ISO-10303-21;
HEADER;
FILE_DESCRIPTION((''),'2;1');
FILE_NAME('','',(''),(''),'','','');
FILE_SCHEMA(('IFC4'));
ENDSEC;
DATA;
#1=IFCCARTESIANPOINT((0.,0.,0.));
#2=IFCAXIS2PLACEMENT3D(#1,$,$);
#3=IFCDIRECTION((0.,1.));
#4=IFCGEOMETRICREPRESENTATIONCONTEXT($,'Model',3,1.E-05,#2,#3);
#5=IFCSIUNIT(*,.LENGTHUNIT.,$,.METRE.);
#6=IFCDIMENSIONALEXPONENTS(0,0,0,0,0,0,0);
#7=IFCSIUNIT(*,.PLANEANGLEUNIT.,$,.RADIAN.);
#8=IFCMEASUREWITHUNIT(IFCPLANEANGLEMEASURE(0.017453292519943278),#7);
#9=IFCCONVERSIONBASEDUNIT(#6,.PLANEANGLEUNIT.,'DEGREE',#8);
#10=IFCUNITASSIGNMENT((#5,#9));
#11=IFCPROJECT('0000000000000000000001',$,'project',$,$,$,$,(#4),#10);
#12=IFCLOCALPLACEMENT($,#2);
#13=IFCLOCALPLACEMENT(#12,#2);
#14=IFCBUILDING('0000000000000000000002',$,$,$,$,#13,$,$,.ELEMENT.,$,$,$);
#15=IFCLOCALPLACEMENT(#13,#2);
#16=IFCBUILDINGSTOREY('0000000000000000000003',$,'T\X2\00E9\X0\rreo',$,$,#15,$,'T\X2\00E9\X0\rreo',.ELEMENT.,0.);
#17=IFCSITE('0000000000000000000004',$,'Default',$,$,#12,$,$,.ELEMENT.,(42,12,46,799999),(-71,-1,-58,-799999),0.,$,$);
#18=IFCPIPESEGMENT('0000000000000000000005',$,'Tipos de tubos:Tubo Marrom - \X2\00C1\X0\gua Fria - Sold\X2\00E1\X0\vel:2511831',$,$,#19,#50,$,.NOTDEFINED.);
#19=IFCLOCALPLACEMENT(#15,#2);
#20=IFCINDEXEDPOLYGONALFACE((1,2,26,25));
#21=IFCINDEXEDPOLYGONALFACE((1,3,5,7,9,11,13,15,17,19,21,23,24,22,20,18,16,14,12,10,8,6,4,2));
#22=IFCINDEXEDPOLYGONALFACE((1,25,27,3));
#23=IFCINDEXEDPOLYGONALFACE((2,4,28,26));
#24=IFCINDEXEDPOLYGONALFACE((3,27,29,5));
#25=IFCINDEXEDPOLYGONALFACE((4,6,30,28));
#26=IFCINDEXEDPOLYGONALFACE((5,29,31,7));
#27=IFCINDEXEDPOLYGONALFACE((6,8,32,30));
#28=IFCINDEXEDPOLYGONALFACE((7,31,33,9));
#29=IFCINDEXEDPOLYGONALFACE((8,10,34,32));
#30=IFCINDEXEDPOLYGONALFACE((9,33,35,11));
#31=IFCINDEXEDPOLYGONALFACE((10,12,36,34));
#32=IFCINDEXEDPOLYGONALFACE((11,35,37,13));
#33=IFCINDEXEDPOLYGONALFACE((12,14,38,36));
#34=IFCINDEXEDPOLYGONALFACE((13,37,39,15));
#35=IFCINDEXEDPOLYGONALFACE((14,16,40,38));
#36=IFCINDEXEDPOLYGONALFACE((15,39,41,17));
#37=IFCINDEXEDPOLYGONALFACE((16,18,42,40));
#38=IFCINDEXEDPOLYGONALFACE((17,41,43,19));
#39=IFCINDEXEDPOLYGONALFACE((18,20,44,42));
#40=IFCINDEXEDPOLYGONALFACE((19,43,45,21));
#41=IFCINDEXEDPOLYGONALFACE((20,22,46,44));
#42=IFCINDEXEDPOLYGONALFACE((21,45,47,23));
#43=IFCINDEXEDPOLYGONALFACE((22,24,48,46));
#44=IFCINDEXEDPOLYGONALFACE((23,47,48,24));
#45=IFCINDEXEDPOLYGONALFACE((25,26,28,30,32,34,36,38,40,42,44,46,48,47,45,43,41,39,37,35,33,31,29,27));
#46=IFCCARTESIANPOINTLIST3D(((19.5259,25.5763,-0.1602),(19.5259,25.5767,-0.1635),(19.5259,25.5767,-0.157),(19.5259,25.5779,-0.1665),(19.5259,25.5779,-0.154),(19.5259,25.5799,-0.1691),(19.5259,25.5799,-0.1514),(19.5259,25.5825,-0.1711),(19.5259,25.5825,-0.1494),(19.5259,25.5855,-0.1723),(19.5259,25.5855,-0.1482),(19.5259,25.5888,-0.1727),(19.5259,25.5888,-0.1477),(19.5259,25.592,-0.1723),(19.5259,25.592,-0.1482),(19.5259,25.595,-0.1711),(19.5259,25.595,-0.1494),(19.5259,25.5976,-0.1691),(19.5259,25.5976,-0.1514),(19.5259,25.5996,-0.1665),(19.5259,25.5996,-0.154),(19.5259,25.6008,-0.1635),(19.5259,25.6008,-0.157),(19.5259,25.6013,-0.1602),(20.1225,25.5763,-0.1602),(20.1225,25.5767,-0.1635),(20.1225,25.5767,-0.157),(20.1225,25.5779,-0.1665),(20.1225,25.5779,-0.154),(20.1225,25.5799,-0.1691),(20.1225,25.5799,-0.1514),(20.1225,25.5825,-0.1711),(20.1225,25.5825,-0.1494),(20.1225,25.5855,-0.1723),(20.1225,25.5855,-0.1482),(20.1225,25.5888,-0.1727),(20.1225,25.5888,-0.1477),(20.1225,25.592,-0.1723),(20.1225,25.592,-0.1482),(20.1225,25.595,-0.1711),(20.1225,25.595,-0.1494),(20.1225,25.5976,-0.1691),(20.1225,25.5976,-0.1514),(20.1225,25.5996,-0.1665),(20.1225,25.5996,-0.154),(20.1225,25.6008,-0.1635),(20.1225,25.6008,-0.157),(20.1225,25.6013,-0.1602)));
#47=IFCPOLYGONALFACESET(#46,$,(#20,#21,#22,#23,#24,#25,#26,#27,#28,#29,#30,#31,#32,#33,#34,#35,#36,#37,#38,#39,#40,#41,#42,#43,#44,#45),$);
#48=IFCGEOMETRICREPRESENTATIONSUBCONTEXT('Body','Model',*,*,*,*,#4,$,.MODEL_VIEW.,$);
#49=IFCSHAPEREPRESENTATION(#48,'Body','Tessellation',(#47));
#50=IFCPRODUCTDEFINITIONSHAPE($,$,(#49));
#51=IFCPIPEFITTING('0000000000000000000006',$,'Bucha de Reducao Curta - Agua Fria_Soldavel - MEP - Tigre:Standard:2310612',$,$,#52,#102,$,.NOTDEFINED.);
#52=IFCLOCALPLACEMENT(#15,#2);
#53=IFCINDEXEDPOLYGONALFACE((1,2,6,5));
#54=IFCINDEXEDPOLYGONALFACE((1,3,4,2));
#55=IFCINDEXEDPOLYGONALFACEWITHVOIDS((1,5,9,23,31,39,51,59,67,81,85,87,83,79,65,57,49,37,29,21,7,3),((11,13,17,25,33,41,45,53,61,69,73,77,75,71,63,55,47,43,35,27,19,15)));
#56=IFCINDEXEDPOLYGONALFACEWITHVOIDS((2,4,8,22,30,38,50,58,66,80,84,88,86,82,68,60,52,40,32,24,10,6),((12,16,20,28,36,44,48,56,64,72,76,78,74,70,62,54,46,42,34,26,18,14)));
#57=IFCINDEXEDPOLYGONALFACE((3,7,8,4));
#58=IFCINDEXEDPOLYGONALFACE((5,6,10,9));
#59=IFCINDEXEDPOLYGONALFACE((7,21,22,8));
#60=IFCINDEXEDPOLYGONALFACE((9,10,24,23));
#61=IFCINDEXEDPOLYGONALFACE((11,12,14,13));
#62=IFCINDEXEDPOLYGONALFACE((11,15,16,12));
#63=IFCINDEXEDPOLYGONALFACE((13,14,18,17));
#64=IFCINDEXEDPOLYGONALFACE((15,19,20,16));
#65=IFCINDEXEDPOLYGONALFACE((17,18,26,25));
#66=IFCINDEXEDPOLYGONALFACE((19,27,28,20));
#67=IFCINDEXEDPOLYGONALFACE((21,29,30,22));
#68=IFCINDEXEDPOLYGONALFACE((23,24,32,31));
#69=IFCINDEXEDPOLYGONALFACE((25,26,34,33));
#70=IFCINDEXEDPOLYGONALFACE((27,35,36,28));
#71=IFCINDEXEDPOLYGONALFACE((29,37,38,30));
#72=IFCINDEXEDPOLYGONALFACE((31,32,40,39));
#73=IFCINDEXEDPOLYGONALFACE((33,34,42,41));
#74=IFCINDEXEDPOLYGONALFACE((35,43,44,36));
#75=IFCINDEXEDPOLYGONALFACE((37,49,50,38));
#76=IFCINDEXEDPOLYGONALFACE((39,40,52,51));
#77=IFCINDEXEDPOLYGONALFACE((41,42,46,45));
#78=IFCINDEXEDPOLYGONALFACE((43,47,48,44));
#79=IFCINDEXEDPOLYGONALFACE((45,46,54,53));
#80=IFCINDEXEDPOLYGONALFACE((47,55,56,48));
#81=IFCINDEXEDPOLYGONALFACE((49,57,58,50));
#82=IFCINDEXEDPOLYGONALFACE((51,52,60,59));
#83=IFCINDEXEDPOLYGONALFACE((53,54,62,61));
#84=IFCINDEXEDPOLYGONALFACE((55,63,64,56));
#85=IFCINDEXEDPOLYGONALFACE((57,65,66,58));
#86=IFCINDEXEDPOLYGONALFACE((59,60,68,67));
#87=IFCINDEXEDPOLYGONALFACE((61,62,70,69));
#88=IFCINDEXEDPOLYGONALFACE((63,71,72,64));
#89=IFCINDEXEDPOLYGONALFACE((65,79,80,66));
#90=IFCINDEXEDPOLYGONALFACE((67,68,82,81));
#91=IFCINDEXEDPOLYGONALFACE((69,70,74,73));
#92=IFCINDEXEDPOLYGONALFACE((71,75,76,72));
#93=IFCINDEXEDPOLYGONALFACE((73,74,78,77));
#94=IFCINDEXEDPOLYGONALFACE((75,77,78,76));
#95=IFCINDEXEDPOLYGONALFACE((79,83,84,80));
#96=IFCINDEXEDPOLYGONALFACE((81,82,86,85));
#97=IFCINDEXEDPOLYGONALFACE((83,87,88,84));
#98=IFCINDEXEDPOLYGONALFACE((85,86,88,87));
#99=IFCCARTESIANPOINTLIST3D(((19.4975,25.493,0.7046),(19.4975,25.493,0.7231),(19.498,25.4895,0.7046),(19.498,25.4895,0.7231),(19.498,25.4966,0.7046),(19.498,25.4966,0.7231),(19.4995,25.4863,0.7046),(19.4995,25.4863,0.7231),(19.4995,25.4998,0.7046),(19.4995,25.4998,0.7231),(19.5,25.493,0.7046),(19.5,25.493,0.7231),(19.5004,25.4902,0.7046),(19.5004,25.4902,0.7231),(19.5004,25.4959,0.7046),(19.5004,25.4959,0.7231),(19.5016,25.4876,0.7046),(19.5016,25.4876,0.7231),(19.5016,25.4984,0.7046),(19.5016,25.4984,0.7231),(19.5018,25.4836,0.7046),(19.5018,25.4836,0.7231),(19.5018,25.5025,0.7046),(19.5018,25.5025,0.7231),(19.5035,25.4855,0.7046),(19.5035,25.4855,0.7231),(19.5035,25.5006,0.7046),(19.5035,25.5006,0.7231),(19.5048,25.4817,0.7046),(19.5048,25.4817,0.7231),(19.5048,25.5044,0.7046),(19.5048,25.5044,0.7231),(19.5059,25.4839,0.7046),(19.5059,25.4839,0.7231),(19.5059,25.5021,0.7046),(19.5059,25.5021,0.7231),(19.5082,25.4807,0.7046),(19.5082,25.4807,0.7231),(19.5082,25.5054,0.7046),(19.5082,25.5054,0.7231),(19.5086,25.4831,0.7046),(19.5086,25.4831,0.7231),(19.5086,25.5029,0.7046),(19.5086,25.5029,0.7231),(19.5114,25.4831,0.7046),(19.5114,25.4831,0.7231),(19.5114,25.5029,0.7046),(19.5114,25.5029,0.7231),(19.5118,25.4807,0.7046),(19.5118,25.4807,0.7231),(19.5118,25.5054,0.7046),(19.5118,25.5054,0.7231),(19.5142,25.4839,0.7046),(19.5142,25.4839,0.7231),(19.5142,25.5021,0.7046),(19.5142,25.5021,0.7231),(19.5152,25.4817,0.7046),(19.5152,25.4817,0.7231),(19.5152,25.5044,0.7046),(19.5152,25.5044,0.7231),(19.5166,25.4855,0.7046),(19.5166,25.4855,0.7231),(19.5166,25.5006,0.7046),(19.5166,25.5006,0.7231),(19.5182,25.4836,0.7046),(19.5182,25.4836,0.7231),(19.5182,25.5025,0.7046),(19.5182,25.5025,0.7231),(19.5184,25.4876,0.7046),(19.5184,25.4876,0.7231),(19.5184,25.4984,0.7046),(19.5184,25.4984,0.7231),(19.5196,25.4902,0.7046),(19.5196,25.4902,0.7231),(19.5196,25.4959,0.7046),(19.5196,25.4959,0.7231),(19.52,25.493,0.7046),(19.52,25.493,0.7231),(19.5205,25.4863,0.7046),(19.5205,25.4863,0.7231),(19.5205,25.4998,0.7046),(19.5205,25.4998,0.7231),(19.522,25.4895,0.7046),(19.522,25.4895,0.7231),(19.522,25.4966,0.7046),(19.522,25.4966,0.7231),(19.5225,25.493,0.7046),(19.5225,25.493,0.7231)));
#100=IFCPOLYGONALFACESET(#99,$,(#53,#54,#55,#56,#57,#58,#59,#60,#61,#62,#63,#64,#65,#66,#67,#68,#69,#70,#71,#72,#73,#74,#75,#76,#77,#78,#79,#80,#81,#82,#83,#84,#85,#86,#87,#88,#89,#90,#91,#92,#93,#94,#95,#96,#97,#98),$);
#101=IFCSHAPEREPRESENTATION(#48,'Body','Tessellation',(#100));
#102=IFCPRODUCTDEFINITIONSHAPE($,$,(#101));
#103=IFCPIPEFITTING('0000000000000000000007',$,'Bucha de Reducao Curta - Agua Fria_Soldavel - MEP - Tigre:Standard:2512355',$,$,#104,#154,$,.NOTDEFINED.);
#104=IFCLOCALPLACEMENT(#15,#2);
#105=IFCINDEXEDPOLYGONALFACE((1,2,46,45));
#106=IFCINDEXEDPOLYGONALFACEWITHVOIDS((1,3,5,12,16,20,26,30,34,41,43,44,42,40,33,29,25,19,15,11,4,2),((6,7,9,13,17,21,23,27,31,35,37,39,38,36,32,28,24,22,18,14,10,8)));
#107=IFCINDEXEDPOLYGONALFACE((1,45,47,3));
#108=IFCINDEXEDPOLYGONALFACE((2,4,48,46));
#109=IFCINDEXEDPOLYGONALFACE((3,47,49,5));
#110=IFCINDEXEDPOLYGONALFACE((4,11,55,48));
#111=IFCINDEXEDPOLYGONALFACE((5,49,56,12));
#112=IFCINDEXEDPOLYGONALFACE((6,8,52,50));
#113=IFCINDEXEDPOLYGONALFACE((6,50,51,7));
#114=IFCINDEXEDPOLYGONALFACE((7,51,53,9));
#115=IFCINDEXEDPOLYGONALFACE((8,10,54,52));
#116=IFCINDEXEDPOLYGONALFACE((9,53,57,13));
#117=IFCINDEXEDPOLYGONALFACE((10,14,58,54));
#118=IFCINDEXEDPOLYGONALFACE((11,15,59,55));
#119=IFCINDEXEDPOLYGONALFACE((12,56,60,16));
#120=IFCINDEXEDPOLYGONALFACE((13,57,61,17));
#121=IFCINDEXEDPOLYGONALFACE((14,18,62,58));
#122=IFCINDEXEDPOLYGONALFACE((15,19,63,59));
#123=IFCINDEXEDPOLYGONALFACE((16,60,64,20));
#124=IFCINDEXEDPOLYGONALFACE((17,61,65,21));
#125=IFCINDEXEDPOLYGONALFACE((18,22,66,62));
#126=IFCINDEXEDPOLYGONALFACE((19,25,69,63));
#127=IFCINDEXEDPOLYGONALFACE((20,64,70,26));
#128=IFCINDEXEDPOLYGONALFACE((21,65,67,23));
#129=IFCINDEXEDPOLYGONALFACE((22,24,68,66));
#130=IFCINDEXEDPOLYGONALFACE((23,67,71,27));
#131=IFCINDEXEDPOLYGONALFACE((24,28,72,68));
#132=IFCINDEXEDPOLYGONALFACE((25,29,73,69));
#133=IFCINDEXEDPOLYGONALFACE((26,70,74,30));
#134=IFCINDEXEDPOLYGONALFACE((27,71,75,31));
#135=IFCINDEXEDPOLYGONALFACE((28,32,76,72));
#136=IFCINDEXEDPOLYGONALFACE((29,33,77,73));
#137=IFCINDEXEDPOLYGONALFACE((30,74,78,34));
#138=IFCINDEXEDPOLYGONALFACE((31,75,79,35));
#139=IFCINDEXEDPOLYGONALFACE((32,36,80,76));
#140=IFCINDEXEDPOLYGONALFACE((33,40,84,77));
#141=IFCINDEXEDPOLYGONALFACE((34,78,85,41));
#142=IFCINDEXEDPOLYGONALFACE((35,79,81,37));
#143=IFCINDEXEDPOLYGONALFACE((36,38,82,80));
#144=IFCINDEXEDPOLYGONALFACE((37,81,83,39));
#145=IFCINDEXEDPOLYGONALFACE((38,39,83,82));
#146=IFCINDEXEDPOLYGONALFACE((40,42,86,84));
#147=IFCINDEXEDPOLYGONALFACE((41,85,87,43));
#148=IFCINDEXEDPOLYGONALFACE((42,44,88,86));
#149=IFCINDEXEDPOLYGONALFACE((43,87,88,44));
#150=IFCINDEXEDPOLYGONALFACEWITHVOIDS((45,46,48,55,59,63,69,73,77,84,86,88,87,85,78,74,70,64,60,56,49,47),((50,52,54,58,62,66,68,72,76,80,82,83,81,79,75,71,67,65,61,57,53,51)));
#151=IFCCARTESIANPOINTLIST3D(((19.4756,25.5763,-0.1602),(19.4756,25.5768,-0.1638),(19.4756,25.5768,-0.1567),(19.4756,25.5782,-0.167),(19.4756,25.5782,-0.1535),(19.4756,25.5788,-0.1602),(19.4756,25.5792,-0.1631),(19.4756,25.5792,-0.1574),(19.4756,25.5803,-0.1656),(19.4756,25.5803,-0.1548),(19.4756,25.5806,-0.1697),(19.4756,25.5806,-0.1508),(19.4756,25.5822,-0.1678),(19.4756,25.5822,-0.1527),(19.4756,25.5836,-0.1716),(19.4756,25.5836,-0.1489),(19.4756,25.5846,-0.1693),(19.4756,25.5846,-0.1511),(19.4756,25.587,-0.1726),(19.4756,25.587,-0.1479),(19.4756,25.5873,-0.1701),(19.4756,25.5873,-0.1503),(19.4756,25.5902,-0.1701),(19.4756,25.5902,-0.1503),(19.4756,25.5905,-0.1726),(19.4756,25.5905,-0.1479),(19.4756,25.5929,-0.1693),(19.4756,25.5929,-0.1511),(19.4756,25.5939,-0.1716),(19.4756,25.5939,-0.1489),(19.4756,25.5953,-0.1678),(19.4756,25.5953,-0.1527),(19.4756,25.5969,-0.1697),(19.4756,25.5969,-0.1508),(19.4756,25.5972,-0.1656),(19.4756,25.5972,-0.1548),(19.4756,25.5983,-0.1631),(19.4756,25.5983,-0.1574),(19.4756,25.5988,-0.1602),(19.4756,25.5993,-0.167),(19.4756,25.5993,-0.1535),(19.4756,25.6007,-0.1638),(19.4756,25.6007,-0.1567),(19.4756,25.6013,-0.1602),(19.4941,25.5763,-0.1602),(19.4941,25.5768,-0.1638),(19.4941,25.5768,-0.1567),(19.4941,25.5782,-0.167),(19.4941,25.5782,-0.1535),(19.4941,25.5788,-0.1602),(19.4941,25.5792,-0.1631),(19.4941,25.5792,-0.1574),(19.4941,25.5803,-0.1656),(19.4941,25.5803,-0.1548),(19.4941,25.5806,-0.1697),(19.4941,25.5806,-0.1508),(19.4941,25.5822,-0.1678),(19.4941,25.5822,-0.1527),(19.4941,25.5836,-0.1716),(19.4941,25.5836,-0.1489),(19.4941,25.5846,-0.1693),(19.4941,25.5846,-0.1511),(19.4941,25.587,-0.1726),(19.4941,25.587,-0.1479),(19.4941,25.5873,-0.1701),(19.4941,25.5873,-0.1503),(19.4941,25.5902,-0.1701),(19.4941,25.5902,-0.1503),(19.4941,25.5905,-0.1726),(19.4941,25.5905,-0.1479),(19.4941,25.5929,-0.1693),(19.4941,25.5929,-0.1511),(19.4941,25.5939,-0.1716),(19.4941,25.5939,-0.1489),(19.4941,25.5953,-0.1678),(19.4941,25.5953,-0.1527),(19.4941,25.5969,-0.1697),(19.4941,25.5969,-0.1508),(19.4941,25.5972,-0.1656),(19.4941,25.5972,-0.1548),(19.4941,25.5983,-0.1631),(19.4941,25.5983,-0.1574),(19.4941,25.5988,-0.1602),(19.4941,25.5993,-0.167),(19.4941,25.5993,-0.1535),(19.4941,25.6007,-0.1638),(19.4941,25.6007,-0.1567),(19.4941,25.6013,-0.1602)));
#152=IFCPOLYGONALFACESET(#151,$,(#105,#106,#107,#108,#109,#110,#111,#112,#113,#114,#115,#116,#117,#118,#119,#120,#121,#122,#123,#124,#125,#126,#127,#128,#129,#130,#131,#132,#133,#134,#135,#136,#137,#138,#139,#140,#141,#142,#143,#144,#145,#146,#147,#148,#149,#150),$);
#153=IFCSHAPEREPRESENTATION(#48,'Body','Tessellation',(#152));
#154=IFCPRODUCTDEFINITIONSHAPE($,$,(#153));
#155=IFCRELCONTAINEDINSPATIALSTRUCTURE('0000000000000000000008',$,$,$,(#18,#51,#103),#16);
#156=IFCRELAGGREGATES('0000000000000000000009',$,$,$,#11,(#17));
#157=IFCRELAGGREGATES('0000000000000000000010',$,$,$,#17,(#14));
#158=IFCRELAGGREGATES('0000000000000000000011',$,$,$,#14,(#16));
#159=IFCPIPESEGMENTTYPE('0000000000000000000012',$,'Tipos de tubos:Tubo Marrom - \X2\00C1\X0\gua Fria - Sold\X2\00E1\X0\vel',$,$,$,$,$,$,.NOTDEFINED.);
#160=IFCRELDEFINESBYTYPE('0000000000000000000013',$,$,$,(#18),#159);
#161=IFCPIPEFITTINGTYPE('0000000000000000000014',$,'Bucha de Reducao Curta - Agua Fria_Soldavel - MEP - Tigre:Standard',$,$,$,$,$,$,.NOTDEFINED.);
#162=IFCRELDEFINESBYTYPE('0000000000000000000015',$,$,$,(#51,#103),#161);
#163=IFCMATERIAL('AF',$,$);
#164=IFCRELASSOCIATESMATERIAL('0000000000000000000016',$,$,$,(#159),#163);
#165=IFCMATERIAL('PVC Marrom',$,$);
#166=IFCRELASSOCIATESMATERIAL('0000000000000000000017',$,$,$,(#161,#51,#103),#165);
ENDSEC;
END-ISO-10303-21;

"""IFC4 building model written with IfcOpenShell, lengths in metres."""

from ifc_helpers import new_model, entity, si_unit, converted_unit, direction, frame, origin, place, context, subcontext, project, spatial, arc, indexed_curve, outline, extrude, source, transform, mapped, material, type_object, type_shapes, element, save


model = new_model("IFC4")

# Units and contexts
model_context = context("Model", 3, precision=1e-05, world=origin(), true_north=direction((0.0, 1.0)))
body_context = subcontext(model_context, "Body", "Model", "MODEL_VIEW")
ifc_project = project(units=[si_unit("LENGTHUNIT", "METRE"), converted_unit("PLANEANGLEUNIT", "DEGREE", entity("IfcPlaneAngleMeasure", 0.017453292519943278), si_unit("PLANEANGLEUNIT", "RADIAN"), dimensions=[0, 0, 0, 0, 0, 0, 0])], contexts=[model_context])

# Site, building, storey
site_placement = place(None, origin())
site = spatial("IfcSite", under=ifc_project, at=site_placement, Name="Default", CompositionType="ELEMENT", RefLatitude=(42, 12, 46, 799999), RefLongitude=(-71, -1, -58, -799999), RefElevation=0.0)
building_placement = place(site_placement, origin())
building = spatial("IfcBuilding", under=site, at=building_placement, CompositionType="ELEMENT")
storey_placement = place(building_placement, origin())
storey = spatial("IfcBuildingStorey", under=building, at=storey_placement, Name="Térreo", LongName="Térreo", CompositionType="ELEMENT", Elevation=0.0)

# Pipe segment
ifc_material_1 = material(Name="AF")
pipe_segment_type_1 = type_object("IfcPipeSegmentType", Name="Tipos de tubos:Tubo Marrom - Água Fria - Soldável", PredefinedType="NOTDEFINED", material=ifc_material_1)
pipe_segment_1_placement = place(storey_placement, origin())
element("IfcPipeSegment", 1, at=pipe_segment_1_placement, inside=storey, type_object=pipe_segment_type_1, Name="Tipos de tubos:Tubo Marrom - Água Fria - Soldável:2511831", PredefinedType="NOTDEFINED", context=body_context, shape_type="SweptSolid", body=[
    extrude(outline(indexed_curve([(0.0125, 0.0), (0.0088, 0.0088), (0.0, 0.0125), (-0.0088, 0.0088), (-0.0125, 0.0), (-0.0088, -0.0088), (0.0, -0.0125), (0.0088, -0.0088)], segments=[arc(1, 2, 3), arc(3, 4, 5), arc(5, 6, 7), arc(7, 8, 1)], self_intersect=False)), frame((19.5259, 25.5888, -0.1602), z_axis=(1.0, 0.0, 0.0), x_axis=(0.0, -1.0, 0.0)), (0.0, 0.0, 1.0), 0.5966),
])

# Pipe fittings
ifc_material_2 = material(Name="PVC Marrom")
pipe_fitting_type_1 = type_object("IfcPipeFittingType", Name="Bucha de Reducao Curta - Agua Fria_Soldavel - MEP - Tigre:Standard", PredefinedType="NOTDEFINED", material=ifc_material_2)
shared_shape_1 = source(origin(), body_context, "Body", "SweptSolid", [
    extrude(outline(indexed_curve([(-0.0125, 0.0), (0.0, -0.0125), (0.0125, 0.0), (0.0, 0.0125)], segments=[arc(1, 2, 3), arc(3, 4, 1)], self_intersect=False), holes=[indexed_curve([(-0.01, 0.0), (0.0, 0.01), (0.01, 0.0), (0.0, -0.01)], segments=[arc(1, 2, 3), arc(3, 4, 1)], self_intersect=False)]), frame((0.0, 0.0, 0.0), z_axis=(1.0, 0.0, 0.0), x_axis=(0.0, 1.0, 0.0)), (0.0, 0.0, 1.0), 0.0185),
])
type_shapes(pipe_fitting_type_1, [shared_shape_1])
for number, where, z_axis, x_axis, name in (
    (2, (19.51, 25.493, 0.7046), (0.0, 1.0, 0.0), (0.0, 0.0, 1.0), "Bucha de Reducao Curta - Agua Fria_Soldavel - MEP - Tigre:Standard:2310612"),
    (3, (19.4941, 25.5888, -0.1602), (0.0, 0.0, 1.0), (-1.0, 0.0, 0.0), "Bucha de Reducao Curta - Agua Fria_Soldavel - MEP - Tigre:Standard:2512355"),
):
    element("IfcPipeFitting", number, at=place(storey_placement, frame(where, z_axis=z_axis, x_axis=x_axis)), inside=storey, type_object=pipe_fitting_type_1, material=ifc_material_2, Name=name, PredefinedType="NOTDEFINED", context=body_context, shape_type="MappedRepresentation", body=[
        mapped(shared_shape_1, transform((0.0, 0.0, 0.0), scale=1.0)),
    ])

save(model, "model.ifc")
